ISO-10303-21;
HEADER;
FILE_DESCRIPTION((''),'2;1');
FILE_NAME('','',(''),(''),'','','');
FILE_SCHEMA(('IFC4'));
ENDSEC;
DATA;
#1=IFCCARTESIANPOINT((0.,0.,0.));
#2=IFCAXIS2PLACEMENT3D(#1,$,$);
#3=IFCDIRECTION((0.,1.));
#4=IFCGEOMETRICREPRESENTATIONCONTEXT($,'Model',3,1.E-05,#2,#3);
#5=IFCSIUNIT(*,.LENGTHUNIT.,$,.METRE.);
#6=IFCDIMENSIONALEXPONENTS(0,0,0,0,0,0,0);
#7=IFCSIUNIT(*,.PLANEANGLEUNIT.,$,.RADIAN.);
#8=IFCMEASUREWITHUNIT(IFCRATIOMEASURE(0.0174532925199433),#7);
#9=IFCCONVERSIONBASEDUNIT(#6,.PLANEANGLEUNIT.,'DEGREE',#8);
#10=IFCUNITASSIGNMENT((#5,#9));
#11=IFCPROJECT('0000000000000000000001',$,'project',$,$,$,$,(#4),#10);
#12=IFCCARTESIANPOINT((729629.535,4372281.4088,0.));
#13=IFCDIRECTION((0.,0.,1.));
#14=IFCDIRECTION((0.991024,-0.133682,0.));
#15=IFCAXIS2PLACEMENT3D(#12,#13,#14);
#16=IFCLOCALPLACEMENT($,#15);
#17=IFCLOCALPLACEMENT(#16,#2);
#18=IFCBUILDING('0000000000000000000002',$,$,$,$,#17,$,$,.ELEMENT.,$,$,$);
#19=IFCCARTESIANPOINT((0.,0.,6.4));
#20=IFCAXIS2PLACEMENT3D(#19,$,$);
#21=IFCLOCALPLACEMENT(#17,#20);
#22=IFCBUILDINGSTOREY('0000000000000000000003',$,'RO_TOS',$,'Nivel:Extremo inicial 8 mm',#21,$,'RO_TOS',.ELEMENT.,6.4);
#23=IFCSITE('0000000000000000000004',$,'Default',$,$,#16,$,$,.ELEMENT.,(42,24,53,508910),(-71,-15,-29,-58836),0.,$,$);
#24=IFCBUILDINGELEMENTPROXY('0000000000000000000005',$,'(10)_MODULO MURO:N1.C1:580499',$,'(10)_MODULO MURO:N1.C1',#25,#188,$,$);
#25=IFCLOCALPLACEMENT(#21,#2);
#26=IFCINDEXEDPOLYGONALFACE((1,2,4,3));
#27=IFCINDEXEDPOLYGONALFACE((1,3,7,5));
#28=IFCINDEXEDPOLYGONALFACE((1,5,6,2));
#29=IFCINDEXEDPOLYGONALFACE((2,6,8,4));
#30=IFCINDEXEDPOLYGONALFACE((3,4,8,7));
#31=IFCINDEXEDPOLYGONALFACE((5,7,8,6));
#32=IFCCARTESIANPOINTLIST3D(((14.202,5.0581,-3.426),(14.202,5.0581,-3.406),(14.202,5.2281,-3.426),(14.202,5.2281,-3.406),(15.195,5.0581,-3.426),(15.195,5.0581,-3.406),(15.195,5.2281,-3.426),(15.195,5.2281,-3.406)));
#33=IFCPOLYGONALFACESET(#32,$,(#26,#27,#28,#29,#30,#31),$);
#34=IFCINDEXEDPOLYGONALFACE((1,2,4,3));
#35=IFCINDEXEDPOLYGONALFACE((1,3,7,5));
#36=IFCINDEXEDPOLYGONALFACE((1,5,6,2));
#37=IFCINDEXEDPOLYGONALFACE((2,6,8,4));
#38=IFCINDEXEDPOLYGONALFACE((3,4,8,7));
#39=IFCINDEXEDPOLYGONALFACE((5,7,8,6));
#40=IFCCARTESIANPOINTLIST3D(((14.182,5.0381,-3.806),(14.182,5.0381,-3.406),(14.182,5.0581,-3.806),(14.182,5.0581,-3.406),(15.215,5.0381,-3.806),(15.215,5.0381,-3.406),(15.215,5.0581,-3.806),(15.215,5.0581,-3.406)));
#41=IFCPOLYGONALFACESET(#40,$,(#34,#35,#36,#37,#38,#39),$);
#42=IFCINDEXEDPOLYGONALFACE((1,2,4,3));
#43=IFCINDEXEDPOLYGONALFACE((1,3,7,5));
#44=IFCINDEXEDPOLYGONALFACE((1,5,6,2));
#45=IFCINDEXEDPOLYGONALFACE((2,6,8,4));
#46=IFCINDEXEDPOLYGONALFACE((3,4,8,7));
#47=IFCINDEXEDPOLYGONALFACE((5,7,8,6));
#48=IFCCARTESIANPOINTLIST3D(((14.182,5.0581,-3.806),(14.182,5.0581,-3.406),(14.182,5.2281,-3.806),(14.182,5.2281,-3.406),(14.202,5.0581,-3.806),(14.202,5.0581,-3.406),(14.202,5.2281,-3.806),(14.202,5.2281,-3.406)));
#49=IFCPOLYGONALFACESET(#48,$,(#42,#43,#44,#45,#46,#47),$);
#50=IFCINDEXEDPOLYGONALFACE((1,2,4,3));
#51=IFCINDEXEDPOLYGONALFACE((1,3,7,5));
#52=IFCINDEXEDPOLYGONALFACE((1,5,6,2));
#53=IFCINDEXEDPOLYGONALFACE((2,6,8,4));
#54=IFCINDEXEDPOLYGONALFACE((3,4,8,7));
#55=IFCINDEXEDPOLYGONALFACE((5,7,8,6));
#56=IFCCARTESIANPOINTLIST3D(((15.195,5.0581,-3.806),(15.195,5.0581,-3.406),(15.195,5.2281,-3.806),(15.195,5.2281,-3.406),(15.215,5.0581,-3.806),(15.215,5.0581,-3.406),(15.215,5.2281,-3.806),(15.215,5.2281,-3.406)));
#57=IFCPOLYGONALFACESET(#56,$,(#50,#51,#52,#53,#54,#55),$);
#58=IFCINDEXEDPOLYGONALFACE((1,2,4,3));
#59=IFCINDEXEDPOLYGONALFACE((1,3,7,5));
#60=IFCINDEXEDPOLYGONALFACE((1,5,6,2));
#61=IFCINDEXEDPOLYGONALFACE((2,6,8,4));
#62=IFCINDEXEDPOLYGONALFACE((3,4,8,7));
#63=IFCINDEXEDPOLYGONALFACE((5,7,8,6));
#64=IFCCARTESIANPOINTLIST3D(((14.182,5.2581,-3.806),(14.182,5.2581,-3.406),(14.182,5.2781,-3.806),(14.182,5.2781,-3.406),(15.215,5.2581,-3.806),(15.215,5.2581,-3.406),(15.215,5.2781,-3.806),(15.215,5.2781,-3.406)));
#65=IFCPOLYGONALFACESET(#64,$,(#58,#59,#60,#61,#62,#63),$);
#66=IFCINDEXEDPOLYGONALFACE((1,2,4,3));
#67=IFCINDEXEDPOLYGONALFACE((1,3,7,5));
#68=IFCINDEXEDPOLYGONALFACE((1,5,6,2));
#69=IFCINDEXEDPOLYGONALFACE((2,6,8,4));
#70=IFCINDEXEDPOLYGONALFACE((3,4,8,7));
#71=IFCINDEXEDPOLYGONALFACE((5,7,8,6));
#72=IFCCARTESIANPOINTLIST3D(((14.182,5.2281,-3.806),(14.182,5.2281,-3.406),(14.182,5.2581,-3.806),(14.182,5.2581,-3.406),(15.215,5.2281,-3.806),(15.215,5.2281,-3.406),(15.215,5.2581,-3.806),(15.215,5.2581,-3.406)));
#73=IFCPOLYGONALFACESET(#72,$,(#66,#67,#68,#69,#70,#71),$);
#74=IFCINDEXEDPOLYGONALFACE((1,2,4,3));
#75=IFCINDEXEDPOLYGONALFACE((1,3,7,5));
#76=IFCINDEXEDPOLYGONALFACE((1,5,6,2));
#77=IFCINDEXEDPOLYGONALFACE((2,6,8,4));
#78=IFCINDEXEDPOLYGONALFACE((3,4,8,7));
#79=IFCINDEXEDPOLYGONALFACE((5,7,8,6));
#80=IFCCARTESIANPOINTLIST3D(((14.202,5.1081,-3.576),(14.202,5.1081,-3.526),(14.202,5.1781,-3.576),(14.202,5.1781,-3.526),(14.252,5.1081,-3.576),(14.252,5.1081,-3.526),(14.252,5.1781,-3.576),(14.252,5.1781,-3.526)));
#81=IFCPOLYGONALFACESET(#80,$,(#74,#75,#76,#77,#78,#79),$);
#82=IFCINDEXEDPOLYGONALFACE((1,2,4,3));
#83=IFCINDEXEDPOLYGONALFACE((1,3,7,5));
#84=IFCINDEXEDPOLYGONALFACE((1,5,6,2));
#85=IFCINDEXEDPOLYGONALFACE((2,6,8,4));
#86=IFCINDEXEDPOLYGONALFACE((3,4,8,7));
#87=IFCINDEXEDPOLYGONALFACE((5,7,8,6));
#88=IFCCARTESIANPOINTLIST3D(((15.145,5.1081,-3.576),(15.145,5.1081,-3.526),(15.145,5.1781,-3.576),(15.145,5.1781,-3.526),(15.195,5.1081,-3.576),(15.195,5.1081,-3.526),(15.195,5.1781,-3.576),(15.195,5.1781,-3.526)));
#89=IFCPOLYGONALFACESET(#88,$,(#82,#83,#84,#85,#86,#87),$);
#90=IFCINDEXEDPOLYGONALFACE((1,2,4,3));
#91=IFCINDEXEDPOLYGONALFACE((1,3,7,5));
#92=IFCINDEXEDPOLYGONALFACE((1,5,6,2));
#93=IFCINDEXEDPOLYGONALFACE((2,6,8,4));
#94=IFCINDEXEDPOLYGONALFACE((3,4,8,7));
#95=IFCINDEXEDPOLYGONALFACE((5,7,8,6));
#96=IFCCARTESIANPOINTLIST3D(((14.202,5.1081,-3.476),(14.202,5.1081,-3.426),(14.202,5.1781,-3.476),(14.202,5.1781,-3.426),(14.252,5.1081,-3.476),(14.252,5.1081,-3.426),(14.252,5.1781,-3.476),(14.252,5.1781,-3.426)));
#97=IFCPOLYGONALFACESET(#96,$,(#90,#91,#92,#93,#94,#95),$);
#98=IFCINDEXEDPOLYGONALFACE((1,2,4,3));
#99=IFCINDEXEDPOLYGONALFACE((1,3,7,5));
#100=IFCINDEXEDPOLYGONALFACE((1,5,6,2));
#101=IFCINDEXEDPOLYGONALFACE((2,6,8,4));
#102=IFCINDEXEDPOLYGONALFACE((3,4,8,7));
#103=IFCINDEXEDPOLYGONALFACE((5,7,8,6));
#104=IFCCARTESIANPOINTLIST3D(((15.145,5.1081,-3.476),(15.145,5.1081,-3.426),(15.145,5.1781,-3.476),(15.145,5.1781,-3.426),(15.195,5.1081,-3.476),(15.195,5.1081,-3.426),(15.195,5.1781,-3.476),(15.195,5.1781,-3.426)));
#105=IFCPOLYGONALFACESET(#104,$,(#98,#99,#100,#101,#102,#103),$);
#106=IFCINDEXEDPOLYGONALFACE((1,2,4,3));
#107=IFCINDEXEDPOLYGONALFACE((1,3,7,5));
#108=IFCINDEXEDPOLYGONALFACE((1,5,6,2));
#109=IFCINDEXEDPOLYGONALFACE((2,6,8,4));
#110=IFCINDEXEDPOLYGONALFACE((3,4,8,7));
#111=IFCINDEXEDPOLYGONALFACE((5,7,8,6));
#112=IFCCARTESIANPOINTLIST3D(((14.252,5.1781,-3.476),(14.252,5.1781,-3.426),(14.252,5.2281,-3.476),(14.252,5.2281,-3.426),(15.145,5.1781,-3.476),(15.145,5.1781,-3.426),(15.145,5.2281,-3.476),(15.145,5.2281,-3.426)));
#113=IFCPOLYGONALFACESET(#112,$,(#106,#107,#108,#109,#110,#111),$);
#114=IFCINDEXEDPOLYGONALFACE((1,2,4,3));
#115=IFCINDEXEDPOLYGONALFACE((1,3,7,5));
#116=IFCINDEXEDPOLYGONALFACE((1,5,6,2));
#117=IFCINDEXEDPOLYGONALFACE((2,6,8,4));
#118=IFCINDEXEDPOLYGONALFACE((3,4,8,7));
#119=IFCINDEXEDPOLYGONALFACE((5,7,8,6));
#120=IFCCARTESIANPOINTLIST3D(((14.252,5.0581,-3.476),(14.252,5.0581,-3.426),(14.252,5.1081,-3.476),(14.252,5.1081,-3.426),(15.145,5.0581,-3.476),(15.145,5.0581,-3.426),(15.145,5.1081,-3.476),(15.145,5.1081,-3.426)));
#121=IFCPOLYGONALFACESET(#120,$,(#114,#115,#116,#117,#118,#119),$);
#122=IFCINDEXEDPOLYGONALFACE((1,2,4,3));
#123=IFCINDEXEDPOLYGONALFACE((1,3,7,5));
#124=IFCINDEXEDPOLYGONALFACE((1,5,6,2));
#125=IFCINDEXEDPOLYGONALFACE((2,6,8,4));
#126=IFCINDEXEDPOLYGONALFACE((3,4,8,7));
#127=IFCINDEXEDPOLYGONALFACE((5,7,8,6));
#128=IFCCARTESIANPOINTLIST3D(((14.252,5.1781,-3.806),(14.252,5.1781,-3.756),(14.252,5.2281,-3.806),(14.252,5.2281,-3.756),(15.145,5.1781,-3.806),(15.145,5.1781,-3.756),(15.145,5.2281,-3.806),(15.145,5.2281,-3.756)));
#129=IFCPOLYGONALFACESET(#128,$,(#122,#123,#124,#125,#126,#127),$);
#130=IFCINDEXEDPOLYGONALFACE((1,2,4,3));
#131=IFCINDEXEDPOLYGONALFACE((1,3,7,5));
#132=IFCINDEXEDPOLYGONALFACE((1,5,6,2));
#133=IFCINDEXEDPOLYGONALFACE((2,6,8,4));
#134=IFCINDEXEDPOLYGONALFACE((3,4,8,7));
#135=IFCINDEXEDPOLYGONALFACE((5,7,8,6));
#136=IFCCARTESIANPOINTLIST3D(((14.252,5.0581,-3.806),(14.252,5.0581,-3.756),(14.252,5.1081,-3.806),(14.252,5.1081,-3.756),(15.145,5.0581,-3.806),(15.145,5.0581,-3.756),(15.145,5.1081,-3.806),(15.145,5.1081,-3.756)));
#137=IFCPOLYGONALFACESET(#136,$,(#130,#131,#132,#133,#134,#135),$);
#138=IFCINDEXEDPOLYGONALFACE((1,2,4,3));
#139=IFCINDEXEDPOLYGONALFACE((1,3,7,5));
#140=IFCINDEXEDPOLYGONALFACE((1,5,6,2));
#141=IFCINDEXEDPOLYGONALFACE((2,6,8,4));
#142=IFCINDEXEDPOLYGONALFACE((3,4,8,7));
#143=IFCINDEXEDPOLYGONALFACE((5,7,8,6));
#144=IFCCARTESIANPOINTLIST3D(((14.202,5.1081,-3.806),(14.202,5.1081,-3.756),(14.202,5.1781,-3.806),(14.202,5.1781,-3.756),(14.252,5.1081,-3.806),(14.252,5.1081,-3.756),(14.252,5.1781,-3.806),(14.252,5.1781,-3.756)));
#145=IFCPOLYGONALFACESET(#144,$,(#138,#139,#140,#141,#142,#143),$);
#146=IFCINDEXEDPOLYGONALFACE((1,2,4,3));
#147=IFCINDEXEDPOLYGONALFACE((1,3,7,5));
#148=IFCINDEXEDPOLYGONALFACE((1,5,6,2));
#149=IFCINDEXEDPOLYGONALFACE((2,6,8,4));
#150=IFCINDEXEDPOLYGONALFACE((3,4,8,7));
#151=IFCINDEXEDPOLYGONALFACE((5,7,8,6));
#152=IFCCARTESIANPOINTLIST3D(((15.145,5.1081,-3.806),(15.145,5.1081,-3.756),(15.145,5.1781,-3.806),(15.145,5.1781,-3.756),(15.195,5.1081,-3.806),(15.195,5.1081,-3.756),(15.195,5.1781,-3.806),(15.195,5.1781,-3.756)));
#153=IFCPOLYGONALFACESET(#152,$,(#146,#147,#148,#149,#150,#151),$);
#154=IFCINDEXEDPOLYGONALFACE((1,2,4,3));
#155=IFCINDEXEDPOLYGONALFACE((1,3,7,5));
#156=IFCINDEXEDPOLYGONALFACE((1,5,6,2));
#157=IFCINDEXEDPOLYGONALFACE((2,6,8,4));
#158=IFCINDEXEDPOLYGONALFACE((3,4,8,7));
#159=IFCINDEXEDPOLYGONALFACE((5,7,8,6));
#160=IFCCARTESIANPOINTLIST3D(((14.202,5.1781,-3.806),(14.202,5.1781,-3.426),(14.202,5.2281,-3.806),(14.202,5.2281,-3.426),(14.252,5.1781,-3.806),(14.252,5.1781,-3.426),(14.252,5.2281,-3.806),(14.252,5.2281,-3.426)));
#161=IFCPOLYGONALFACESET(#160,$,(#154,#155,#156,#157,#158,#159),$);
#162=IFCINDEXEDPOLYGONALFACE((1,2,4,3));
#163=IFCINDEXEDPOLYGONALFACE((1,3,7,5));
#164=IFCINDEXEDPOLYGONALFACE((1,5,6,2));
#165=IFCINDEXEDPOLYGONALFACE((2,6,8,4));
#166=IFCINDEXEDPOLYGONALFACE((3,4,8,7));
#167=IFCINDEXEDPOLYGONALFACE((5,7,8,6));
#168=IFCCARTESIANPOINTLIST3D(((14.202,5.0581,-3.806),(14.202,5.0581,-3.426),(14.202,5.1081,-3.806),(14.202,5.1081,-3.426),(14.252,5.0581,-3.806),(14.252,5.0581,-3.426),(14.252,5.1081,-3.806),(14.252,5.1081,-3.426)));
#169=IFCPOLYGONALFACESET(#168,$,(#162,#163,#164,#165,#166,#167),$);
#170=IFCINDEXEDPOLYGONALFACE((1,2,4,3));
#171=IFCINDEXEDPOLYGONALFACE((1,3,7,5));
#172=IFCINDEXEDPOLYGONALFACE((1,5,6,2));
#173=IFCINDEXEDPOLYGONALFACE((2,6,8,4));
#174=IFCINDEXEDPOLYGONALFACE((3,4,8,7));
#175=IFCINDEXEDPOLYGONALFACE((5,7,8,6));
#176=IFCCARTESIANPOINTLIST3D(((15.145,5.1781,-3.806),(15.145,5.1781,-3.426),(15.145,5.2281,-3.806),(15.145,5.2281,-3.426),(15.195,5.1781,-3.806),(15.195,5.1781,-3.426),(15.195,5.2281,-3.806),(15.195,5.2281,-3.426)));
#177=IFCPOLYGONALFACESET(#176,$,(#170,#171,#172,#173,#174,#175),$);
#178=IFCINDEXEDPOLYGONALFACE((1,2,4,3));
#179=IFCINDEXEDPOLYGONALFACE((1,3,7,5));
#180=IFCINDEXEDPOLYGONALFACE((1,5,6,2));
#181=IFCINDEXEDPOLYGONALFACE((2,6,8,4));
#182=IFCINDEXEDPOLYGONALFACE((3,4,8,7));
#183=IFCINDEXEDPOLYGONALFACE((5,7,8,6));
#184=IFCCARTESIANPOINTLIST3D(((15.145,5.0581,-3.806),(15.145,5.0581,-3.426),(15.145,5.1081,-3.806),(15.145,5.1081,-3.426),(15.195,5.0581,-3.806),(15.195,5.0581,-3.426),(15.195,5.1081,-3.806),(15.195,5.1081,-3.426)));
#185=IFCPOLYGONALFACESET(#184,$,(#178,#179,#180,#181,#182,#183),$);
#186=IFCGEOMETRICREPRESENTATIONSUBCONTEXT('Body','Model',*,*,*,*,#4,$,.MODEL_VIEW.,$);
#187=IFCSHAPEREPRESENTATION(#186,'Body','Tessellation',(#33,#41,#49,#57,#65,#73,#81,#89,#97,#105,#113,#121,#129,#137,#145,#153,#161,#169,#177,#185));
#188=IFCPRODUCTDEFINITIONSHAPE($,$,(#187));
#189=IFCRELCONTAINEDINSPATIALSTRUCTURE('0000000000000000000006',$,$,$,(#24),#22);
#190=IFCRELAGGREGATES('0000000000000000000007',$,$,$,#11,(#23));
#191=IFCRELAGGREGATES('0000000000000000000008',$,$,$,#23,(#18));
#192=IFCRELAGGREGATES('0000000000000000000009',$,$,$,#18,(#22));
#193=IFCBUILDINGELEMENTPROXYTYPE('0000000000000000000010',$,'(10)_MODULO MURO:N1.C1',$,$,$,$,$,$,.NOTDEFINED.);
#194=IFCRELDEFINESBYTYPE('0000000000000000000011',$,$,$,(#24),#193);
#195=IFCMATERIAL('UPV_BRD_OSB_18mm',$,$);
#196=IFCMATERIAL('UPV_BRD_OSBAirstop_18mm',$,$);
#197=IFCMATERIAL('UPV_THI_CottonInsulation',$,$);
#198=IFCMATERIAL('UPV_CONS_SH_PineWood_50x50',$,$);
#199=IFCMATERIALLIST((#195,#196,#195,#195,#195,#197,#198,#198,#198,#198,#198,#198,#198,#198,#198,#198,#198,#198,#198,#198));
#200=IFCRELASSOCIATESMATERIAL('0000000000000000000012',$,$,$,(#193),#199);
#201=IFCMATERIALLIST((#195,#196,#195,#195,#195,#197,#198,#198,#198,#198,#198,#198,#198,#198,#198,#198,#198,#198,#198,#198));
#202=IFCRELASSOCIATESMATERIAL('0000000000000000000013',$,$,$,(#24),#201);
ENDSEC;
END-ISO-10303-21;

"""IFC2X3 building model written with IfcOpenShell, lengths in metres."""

from ifc_helpers import new_model, entity, si_unit, converted_unit, direction, frame, frame_2d, origin, origin_2d_with_axis, place, context, subcontext, project, spatial, rectangle, extrude, source, transform, mapped, material, material_list, type_object, type_shapes, element, save


model = new_model("IFC2X3")

# Units and contexts
model_context = context("Model", 3, precision=1e-05, world=origin(), true_north=direction((0.0, 1.0)))
body_context = subcontext(model_context, "Body", "Model", "MODEL_VIEW")
ifc_project = project(units=[si_unit("LENGTHUNIT", "METRE"), converted_unit("PLANEANGLEUNIT", "DEGREE", entity("IfcRatioMeasure", 0.0174532925199433), si_unit("PLANEANGLEUNIT", "RADIAN"), dimensions=[0, 0, 0, 0, 0, 0, 0])], contexts=[model_context])

# Site, building, storey
site_placement = place(None, frame((729629.535, 4372281.4088, 0.0), z_axis=(0.0, 0.0, 1.0), x_axis=(0.991024, -0.133682, 0.0)))
site = spatial("IfcSite", under=ifc_project, at=site_placement, Name="Default", CompositionType="ELEMENT", RefLatitude=(42, 24, 53, 508910), RefLongitude=(-71, -15, -29, -58836), RefElevation=0.0)
building_placement = place(site_placement, origin())
building = spatial("IfcBuilding", under=site, at=building_placement, CompositionType="ELEMENT")
storey_placement = place(building_placement, frame((0.0, 0.0, 6.4)))
storey = spatial("IfcBuildingStorey", under=building, at=storey_placement, Name="RO_TOS", ObjectType="Nivel:Extremo inicial 8 mm", LongName="RO_TOS", CompositionType="ELEMENT", Elevation=6.4)

# Building element proxy
ifc_material_1 = material(Name="UPV_BRD_OSB_18mm")
ifc_material_2 = material(Name="UPV_BRD_OSBAirstop_18mm")
ifc_material_3 = material(Name="UPV_THI_CottonInsulation")
ifc_material_4 = material(Name="UPV_CONS_SH_PineWood_50x50")
ifc_material_list_1 = material_list([ifc_material_1, ifc_material_2, ifc_material_1, ifc_material_1, ifc_material_1, ifc_material_3, ifc_material_4, ifc_material_4, ifc_material_4, ifc_material_4, ifc_material_4, ifc_material_4, ifc_material_4, ifc_material_4, ifc_material_4, ifc_material_4, ifc_material_4, ifc_material_4, ifc_material_4, ifc_material_4])
ifc_material_list_2 = material_list([ifc_material_1, ifc_material_2, ifc_material_1, ifc_material_1, ifc_material_1, ifc_material_3, ifc_material_4, ifc_material_4, ifc_material_4, ifc_material_4, ifc_material_4, ifc_material_4, ifc_material_4, ifc_material_4, ifc_material_4, ifc_material_4, ifc_material_4, ifc_material_4, ifc_material_4, ifc_material_4])
building_element_proxy_type_1 = type_object("IfcBuildingElementProxyType", Name="(10)_MODULO MURO:N1.C1", PredefinedType="NOTDEFINED", material=ifc_material_list_2)
shared_shape_1 = source(origin(), body_context, "Body", "SweptSolid", [
    extrude(rectangle(XDim=0.993, YDim=0.17, at=frame_2d((0.0, 0.0), x_axis=(1.0, 0.0))), frame((0.0, 0.0, 0.38), z_axis=(0.0, 0.0, 1.0), x_axis=(-1.0, 0.0, 0.0)), (0.0, 0.0, 1.0), 0.02),
    extrude(rectangle(XDim=1.033, YDim=0.02, at=origin_2d_with_axis()), frame((0.0, -0.095, 0.0)), (0.0, 0.0, 1.0), 0.4),
    extrude(rectangle(XDim=0.17, YDim=0.02, at=frame_2d((0.0, 0.0), x_axis=(1.0, 0.0))), frame((-0.5065, 0.0, 0.0), z_axis=(0.0, 0.0, 1.0), x_axis=(0.0, -1.0, 0.0)), (0.0, 0.0, 1.0), 0.4),
    extrude(rectangle(XDim=0.17, YDim=0.02, at=frame_2d((0.0, 0.0), x_axis=(1.0, 0.0))), frame((0.5065, 0.0, 0.0), z_axis=(0.0, 0.0, 1.0), x_axis=(0.0, -1.0, 0.0)), (0.0, 0.0, 1.0), 0.4),
    extrude(rectangle(XDim=1.033, YDim=0.02, at=origin_2d_with_axis()), frame((0.0, 0.125, 0.0), z_axis=(0.0, 0.0, 1.0), x_axis=(-1.0, 0.0, 0.0)), (0.0, 0.0, 1.0), 0.4),
    extrude(rectangle(XDim=1.033, YDim=0.03, at=frame_2d((0.0, 0.0), x_axis=(1.0, 0.0))), frame((0.0, 0.1, 0.0), z_axis=(0.0, 0.0, 1.0), x_axis=(-1.0, 0.0, 0.0)), (0.0, 0.0, 1.0), 0.4),
    extrude(rectangle(XDim=0.07, YDim=0.05, at=frame_2d((0.0, 0.0), x_axis=(1.0, 0.0))), frame((-0.4715, 0.0, 0.23), z_axis=(0.0, 0.0, 1.0), x_axis=(0.0, 1.0, 0.0)), (0.0, 0.0, 1.0), 0.05),
    extrude(rectangle(XDim=0.07, YDim=0.05, at=origin_2d_with_axis()), frame((0.4715, 0.0, 0.23), z_axis=(0.0, 0.0, 1.0), x_axis=(0.0, 1.0, 0.0)), (0.0, 0.0, 1.0), 0.05),
    extrude(rectangle(XDim=0.07, YDim=0.05, at=frame_2d((0.0, 0.0), x_axis=(1.0, 0.0))), frame((-0.4715, 0.0, 0.33), z_axis=(0.0, 0.0, 1.0), x_axis=(0.0, -1.0, 0.0)), (0.0, 0.0, 1.0), 0.05),
    extrude(rectangle(XDim=0.07, YDim=0.05, at=frame_2d((0.0, 0.0), x_axis=(1.0, 0.0))), frame((0.4715, 0.0, 0.33), z_axis=(0.0, 0.0, 1.0), x_axis=(0.0, -1.0, 0.0)), (0.0, 0.0, 1.0), 0.05),
    extrude(rectangle(XDim=0.893, YDim=0.05, at=origin_2d_with_axis()), frame((0.0, 0.06, 0.33), z_axis=(0.0, 0.0, 1.0), x_axis=(-1.0, 0.0, 0.0)), (0.0, 0.0, 1.0), 0.05),
    extrude(rectangle(XDim=0.05, YDim=0.893, at=frame_2d((0.0, 0.0), x_axis=(1.0, 0.0))), frame((0.0, -0.06, 0.33), z_axis=(0.0, 0.0, 1.0), x_axis=(0.0, -1.0, 0.0)), (0.0, 0.0, 1.0), 0.05),
    extrude(rectangle(XDim=0.05, YDim=0.893, at=origin_2d_with_axis()), frame((0.0, 0.06, 0.0), z_axis=(0.0, 0.0, 1.0), x_axis=(0.0, -1.0, 0.0)), (0.0, 0.0, 1.0), 0.05),
    extrude(rectangle(XDim=0.05, YDim=0.893, at=frame_2d((0.0, 0.0), x_axis=(1.0, 0.0))), frame((0.0, -0.06, 0.0), z_axis=(0.0, 0.0, 1.0), x_axis=(0.0, -1.0, 0.0)), (0.0, 0.0, 1.0), 0.05),
    extrude(rectangle(XDim=0.07, YDim=0.05, at=frame_2d((0.0, 0.0), x_axis=(1.0, 0.0))), frame((-0.4715, 0.0, 0.0), z_axis=(0.0, 0.0, 1.0), x_axis=(0.0, -1.0, 0.0)), (0.0, 0.0, 1.0), 0.05),
    extrude(rectangle(XDim=0.05, YDim=0.07, at=frame_2d((0.0, 0.0), x_axis=(1.0, 0.0))), frame((0.4715, 0.0, 0.0), z_axis=(0.0, 0.0, 1.0), x_axis=(-1.0, 0.0, 0.0)), (0.0, 0.0, 1.0), 0.05),
    extrude(rectangle(XDim=0.05, YDim=0.05, at=frame_2d((0.0, 0.0), x_axis=(1.0, 0.0))), frame((-0.4715, 0.06, 0.0), z_axis=(0.0, 0.0, 1.0), x_axis=(0.0, -1.0, 0.0)), (0.0, 0.0, 1.0), 0.38),
    extrude(rectangle(XDim=0.05, YDim=0.05, at=frame_2d((0.0, 0.0), x_axis=(1.0, 0.0))), frame((-0.4715, -0.06, 0.0), z_axis=(0.0, 0.0, 1.0), x_axis=(0.0, -1.0, 0.0)), (0.0, 0.0, 1.0), 0.38),
    extrude(rectangle(XDim=0.05, YDim=0.05, at=frame_2d((0.0, 0.0), x_axis=(1.0, 0.0))), frame((0.4715, 0.06, 0.0), z_axis=(0.0, 0.0, 1.0), x_axis=(0.0, -1.0, 0.0)), (0.0, 0.0, 1.0), 0.38),
    extrude(rectangle(XDim=0.05, YDim=0.05, at=frame_2d((0.0, 0.0), x_axis=(1.0, 0.0))), frame((0.4715, -0.06, 0.0), z_axis=(0.0, 0.0, 1.0), x_axis=(0.0, -1.0, 0.0)), (0.0, 0.0, 1.0), 0.38),
])
type_shapes(building_element_proxy_type_1, [shared_shape_1])
proxy_1_placement = place(storey_placement, frame((14.6985, 5.1431, -3.806)))
element("IfcBuildingElementProxy", 1, at=proxy_1_placement, inside=storey, type_object=building_element_proxy_type_1, material=ifc_material_list_1, Name="(10)_MODULO MURO:N1.C1:580499", ObjectType="(10)_MODULO MURO:N1.C1", context=body_context, shape_type="MappedRepresentation", body=[
    mapped(shared_shape_1, transform((0.0, 0.0, 0.0), scale=1.0)),
])

save(model, "model.ifc")
